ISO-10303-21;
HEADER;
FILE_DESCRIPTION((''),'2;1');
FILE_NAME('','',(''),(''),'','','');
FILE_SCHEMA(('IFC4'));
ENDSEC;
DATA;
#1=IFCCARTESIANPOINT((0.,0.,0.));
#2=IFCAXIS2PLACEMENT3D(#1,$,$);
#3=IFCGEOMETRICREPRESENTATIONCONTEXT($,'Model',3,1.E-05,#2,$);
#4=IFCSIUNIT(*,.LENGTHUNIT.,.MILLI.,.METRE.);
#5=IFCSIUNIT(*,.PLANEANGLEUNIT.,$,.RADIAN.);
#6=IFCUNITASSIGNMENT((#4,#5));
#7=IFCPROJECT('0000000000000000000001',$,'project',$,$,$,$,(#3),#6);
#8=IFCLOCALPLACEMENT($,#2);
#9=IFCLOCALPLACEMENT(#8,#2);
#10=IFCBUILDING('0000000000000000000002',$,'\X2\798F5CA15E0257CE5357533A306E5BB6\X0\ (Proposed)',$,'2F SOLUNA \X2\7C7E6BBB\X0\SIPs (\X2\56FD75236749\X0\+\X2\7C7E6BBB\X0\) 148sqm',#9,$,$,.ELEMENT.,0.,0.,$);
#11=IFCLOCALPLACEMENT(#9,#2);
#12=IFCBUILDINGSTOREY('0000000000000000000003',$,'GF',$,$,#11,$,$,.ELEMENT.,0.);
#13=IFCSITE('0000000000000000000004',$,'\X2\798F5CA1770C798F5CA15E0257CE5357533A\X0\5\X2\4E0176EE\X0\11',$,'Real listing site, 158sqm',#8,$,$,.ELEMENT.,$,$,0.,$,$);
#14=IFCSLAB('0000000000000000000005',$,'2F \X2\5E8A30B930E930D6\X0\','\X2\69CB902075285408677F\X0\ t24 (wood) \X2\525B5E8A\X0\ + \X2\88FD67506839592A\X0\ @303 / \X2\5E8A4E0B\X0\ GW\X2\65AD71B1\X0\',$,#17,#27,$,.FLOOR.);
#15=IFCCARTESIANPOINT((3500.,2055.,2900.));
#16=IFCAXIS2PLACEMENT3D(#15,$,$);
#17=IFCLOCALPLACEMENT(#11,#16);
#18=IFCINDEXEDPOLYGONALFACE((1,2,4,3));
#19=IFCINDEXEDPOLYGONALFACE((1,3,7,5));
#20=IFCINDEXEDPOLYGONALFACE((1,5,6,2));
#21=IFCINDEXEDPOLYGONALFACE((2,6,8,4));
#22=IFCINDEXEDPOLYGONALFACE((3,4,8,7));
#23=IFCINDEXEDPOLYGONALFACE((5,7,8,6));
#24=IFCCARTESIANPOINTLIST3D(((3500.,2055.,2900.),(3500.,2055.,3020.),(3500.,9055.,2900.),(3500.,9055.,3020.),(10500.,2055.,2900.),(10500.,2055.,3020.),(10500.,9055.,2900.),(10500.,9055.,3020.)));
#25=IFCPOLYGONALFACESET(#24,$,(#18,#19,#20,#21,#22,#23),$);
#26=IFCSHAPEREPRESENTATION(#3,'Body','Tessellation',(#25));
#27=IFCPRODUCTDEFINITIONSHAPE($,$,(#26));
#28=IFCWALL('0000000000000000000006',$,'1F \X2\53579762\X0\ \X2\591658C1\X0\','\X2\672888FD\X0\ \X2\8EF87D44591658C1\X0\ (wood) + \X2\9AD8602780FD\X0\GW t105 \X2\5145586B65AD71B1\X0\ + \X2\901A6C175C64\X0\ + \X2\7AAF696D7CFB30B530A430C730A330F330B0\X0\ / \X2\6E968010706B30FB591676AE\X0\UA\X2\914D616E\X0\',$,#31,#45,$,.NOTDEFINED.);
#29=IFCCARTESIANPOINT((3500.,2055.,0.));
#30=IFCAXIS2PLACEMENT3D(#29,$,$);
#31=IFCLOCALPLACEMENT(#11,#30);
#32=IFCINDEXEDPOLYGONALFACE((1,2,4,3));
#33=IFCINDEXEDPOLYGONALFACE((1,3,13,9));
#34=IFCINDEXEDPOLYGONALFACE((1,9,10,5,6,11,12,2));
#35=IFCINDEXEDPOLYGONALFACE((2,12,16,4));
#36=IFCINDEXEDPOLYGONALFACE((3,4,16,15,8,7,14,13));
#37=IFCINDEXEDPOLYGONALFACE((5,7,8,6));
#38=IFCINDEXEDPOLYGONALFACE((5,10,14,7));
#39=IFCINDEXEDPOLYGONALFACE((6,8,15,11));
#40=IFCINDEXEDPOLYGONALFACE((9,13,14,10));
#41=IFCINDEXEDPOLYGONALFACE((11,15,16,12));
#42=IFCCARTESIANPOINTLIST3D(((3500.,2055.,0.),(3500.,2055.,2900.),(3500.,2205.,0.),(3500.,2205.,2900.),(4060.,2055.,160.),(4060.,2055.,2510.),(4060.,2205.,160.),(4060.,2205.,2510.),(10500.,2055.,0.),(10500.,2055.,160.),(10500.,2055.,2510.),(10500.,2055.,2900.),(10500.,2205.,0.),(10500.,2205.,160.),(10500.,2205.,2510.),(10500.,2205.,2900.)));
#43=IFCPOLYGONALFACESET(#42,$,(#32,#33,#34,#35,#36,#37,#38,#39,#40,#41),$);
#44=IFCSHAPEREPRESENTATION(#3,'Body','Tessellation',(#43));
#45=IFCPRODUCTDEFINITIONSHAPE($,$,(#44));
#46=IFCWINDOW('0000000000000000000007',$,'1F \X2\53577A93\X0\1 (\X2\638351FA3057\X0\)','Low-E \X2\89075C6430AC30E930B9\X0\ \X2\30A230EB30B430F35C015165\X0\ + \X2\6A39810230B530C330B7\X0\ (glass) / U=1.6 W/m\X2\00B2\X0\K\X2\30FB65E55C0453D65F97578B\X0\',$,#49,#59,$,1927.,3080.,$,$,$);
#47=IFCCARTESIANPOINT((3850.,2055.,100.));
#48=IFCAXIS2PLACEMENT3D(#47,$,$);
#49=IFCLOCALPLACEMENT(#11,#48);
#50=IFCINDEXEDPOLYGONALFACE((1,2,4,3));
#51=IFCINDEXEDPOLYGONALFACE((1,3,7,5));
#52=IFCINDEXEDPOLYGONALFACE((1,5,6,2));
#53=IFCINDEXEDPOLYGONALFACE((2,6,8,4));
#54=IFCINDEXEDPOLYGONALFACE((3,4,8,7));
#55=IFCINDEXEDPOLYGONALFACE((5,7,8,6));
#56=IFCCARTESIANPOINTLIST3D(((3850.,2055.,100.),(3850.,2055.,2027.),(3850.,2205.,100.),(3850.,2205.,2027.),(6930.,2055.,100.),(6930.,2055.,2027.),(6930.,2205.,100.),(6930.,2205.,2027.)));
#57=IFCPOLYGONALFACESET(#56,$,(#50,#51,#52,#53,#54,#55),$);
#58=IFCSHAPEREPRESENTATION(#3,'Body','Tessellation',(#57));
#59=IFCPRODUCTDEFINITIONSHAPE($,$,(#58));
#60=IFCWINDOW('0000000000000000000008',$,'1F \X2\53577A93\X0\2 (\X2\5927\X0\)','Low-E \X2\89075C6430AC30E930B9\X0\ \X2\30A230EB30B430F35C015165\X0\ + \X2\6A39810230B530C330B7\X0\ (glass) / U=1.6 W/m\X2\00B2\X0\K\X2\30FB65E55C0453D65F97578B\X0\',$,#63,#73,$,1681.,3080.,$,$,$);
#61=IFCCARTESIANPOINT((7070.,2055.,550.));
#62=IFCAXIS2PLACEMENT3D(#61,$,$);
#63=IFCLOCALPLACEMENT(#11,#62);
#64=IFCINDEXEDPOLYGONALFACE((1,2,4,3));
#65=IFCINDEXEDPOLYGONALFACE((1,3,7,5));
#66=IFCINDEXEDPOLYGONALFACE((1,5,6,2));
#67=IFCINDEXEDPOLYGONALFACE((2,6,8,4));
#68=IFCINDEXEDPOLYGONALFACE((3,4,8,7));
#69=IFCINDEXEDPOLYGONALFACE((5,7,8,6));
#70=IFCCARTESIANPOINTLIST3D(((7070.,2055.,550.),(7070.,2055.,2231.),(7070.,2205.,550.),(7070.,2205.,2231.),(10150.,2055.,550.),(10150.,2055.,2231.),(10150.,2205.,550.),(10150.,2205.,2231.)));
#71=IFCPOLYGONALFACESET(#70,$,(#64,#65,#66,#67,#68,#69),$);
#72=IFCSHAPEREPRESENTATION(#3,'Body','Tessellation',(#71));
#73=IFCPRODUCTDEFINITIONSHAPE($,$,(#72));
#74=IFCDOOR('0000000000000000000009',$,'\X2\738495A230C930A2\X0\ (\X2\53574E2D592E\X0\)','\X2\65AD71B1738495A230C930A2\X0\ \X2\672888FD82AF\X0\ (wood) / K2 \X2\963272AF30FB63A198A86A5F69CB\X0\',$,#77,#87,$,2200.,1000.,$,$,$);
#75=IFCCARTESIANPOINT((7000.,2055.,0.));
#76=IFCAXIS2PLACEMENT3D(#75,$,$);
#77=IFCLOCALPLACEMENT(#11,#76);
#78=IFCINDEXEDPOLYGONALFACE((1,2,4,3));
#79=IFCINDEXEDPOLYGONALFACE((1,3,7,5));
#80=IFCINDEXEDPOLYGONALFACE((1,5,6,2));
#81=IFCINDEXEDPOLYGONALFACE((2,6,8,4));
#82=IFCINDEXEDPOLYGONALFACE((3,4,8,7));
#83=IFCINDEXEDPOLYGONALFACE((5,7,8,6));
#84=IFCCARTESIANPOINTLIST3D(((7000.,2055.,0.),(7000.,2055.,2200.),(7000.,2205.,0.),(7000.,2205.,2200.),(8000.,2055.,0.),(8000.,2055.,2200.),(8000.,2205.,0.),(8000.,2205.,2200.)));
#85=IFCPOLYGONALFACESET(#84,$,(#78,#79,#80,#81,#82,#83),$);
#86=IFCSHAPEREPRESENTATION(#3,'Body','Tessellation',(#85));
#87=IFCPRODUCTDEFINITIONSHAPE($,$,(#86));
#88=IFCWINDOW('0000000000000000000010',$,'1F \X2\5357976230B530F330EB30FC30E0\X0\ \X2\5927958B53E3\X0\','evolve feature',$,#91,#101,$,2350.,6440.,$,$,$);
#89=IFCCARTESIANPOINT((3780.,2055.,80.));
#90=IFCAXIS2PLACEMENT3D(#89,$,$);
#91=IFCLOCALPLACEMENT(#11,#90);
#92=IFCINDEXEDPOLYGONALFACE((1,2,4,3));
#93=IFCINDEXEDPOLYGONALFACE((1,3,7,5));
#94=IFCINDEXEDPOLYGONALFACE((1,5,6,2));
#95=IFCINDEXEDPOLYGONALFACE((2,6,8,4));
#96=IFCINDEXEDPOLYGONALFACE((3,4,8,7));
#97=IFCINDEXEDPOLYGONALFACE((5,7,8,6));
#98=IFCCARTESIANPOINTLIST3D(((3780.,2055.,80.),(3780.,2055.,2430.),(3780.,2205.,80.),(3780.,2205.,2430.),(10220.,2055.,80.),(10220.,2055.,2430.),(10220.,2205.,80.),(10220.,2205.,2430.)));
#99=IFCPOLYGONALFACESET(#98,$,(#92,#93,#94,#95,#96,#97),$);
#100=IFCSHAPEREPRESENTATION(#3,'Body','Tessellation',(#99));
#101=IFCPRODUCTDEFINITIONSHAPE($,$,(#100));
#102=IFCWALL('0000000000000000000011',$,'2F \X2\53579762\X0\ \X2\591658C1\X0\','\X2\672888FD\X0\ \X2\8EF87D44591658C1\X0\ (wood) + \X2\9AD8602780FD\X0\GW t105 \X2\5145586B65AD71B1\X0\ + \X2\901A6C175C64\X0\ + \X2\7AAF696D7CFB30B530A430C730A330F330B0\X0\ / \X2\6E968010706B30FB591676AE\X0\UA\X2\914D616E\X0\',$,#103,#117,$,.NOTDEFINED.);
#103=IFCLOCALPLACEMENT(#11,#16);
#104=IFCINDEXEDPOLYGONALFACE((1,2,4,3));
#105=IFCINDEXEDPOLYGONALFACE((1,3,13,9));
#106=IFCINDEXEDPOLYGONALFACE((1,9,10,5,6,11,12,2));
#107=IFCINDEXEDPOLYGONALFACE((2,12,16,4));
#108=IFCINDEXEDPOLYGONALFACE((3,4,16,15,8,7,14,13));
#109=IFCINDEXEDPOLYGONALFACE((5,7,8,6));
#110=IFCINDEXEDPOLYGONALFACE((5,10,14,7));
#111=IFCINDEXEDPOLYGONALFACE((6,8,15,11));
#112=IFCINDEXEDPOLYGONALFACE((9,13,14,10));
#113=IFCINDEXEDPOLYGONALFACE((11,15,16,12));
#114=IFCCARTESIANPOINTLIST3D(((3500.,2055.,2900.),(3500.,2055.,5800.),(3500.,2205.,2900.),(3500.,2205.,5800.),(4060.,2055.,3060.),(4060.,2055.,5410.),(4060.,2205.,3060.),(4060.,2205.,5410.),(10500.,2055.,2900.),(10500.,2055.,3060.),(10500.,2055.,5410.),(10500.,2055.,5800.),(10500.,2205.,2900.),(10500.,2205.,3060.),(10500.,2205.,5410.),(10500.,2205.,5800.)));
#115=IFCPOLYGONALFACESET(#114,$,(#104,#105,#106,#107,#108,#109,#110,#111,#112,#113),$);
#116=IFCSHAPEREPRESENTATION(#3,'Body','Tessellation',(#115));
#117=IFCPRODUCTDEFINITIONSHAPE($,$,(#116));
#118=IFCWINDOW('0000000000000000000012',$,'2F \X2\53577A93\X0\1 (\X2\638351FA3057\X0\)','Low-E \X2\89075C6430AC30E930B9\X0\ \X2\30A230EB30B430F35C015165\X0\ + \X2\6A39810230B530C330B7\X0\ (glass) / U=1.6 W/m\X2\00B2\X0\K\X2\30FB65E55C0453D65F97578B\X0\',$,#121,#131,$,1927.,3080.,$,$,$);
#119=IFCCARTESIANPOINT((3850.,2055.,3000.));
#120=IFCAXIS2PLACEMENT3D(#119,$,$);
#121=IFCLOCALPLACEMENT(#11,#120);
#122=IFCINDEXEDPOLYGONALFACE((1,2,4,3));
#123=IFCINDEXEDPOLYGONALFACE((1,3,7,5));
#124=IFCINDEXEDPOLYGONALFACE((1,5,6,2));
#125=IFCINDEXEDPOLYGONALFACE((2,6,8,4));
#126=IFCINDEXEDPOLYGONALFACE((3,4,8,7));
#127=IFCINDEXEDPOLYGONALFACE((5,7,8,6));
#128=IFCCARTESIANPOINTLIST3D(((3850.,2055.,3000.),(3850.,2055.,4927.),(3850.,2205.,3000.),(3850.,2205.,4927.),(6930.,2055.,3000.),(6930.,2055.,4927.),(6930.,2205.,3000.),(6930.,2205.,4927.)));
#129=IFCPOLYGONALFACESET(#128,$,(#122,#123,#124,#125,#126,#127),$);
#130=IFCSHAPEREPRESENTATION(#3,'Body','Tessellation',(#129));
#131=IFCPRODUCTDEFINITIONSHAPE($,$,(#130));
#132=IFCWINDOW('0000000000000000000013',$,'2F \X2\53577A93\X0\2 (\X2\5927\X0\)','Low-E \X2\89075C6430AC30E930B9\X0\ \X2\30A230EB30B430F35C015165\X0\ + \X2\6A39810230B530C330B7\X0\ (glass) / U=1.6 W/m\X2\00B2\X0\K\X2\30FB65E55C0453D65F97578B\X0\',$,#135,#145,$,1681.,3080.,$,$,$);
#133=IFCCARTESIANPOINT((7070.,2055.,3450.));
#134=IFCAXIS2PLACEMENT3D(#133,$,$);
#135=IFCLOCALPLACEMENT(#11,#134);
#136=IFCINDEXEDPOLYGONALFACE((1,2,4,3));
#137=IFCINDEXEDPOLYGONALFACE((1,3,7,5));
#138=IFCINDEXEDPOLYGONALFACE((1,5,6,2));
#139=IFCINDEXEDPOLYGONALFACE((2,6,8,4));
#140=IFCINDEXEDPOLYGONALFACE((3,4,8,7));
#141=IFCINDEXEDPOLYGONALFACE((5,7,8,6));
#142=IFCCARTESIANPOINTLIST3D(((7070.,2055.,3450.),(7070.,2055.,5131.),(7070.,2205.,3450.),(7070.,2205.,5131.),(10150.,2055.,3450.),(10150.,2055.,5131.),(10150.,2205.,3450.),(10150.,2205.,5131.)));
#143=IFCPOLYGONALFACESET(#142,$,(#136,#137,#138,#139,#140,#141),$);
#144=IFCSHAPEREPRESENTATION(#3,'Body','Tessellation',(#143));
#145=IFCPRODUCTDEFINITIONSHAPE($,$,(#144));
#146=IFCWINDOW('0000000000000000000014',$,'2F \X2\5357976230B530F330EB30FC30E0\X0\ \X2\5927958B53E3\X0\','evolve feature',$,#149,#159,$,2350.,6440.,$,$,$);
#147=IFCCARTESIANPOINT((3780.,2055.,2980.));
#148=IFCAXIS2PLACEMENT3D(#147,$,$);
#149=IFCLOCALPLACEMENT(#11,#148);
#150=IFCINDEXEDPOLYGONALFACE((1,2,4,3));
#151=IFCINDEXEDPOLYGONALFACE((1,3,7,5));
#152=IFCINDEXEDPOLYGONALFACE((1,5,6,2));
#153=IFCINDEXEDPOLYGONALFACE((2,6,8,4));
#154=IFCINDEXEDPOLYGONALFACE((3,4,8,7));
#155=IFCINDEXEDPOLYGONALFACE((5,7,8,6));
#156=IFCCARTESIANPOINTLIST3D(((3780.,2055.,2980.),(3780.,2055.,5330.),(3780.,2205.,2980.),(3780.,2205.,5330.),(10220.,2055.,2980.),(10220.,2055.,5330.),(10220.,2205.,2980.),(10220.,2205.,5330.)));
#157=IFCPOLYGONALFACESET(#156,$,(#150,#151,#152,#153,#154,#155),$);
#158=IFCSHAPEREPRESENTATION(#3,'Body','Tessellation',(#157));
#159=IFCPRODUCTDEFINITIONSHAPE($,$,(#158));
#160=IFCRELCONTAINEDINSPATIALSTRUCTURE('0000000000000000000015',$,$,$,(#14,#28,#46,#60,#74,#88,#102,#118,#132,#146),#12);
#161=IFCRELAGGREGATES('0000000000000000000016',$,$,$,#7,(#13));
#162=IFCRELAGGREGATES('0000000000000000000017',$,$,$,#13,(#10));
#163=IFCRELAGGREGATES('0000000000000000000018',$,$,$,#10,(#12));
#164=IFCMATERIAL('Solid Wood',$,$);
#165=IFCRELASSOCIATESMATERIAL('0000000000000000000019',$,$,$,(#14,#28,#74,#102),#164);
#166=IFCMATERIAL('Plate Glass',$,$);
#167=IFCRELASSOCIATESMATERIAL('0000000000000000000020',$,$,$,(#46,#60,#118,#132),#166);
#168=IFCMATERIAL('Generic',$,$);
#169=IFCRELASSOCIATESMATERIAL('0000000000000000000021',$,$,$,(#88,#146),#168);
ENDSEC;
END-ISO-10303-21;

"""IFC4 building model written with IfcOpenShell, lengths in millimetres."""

from ifc_helpers import new_model, si_unit, frame, frame_2d, origin, place, context, project, spatial, rectangle, extrude, material, element, fill, save


model = new_model("IFC4")

# Units and contexts
model_context = context("Model", 3, precision=1e-05, world=origin())
ifc_project = project(units=[si_unit("LENGTHUNIT", "METRE", prefix="MILLI"), si_unit("PLANEANGLEUNIT", "RADIAN")], contexts=[model_context])

# Site, building, storey
site_placement = place(None, origin())
site = spatial("IfcSite", under=ifc_project, at=site_placement, Name="福岡県福岡市城南区5丁目11", ObjectType="Real listing site, 158sqm", CompositionType="ELEMENT", RefElevation=0.0)
building_placement = place(site_placement, origin())
building = spatial("IfcBuilding", under=site, at=building_placement, Name="福岡市城南区の家 (Proposed)", ObjectType="2F SOLUNA 籾殻SIPs (国産杉+籾殻) 148sqm", CompositionType="ELEMENT", ElevationOfRefHeight=0.0, ElevationOfTerrain=0.0)
storey_placement = place(building_placement, origin())
storey = spatial("IfcBuildingStorey", under=building, at=storey_placement, Name="GF", CompositionType="ELEMENT", Elevation=0.0)

# Slab
ifc_material_1 = material(Name="Solid Wood")
slab_1_placement = place(storey_placement, frame((3500.0, 2055.0, 2900.0)))
element("IfcSlab", 1, at=slab_1_placement, inside=storey, material=ifc_material_1, Name="2F 床スラブ", Description="構造用合板 t24 (wood) 剛床 + 製材根太 @303 / 床下 GW断熱", PredefinedType="FLOOR", context=model_context, shape_type="SweptSolid", body=[
    extrude(rectangle(XDim=7000.0, YDim=7000.0, at=frame_2d((3500.0, 3500.0))), frame((3500.0, 2055.0, 2900.0)), (0.0, 0.0, 1.0), 120.0),
])
ifc_material_2 = material(Name="Generic")

# Wall, openings, windows, door
wall_1_placement = place(storey_placement, frame((3500.0, 2055.0, 0.0)))
wall_1 = element("IfcWall", 2, at=wall_1_placement, inside=storey, material=ifc_material_1, Name="1F 南面 外壁", Description="木製 軸組外壁 (wood) + 高性能GW t105 充填断熱 + 通気層 + 窯業系サイディング / 準耐火・外皮UA配慮", PredefinedType="NOTDEFINED", context=model_context, shape_type="SweptSolid", body=[
    extrude(rectangle(XDim=7000.0, YDim=150.0, at=frame_2d((3500.0, 75.0))), frame((3500.0, 2055.0, 0.0)), (0.0, 0.0, 1.0), 2900.0),
])
opening_1_placement = place(storey_placement, frame((3850.0, 2055.0, 100.0)))
opening_1 = element("IfcOpeningElement", 3, at=opening_1_placement, cuts=wall_1, PredefinedType="NOTDEFINED", context=model_context, shape_type="SweptSolid", body=[
    extrude(rectangle(XDim=3080.0, YDim=150.0, at=frame_2d((1540.0, 75.0))), frame((3850.0, 2055.0, 100.0)), (0.0, 0.0, 1.0), 1927.0),
])
opening_2_placement = place(storey_placement, frame((7070.0, 2055.0, 550.0)))
opening_2 = element("IfcOpeningElement", 4, at=opening_2_placement, cuts=wall_1, PredefinedType="NOTDEFINED", context=model_context, shape_type="SweptSolid", body=[
    extrude(rectangle(XDim=3080.0, YDim=150.0, at=frame_2d((1540.0, 75.0))), frame((7070.0, 2055.0, 550.0)), (0.0, 0.0, 1.0), 1681.0),
])
opening_3_placement = place(storey_placement, frame((7000.0, 2055.0, 0.0)))
opening_3 = element("IfcOpeningElement", 5, at=opening_3_placement, cuts=wall_1, PredefinedType="NOTDEFINED", context=model_context, shape_type="SweptSolid", body=[
    extrude(rectangle(XDim=1000.0, YDim=150.0, at=frame_2d((500.0, 75.0))), frame((7000.0, 2055.0, 0.0)), (0.0, 0.0, 1.0), 2200.0),
])
opening_4_placement = place(storey_placement, frame((3780.0, 2055.0, 80.0)))
opening_4 = element("IfcOpeningElement", 6, at=opening_4_placement, cuts=wall_1, PredefinedType="NOTDEFINED", context=model_context, shape_type="SweptSolid", body=[
    extrude(rectangle(XDim=6440.0, YDim=150.0, at=frame_2d((3220.0, 75.0))), frame((3780.0, 2055.0, 80.0)), (0.0, 0.0, 1.0), 2350.0),
])
ifc_material_3 = material(Name="Plate Glass")
window_1_placement = place(storey_placement, frame((3850.0, 2055.0, 100.0)))
window_1 = element("IfcWindow", 7, at=window_1_placement, inside=storey, material=ifc_material_3, Name="1F 南窓1 (掃出し)", Description="Low-E 複層ガラス アルゴン封入 + 樹脂サッシ (glass) / U=1.6 W/m²K・日射取得型", OverallHeight=1927.0, OverallWidth=3080.0, context=model_context, shape_type="SweptSolid", body=[
    extrude(rectangle(XDim=3080.0, YDim=150.0, at=frame_2d((1540.0, 75.0))), frame((3850.0, 2055.0, 100.0)), (0.0, 0.0, 1.0), 1927.0),
])
fill(opening_1, window_1)
window_2_placement = place(storey_placement, frame((7070.0, 2055.0, 550.0)))
window_2 = element("IfcWindow", 8, at=window_2_placement, inside=storey, material=ifc_material_3, Name="1F 南窓2 (大)", Description="Low-E 複層ガラス アルゴン封入 + 樹脂サッシ (glass) / U=1.6 W/m²K・日射取得型", OverallHeight=1681.0, OverallWidth=3080.0, context=model_context, shape_type="SweptSolid", body=[
    extrude(rectangle(XDim=3080.0, YDim=150.0, at=frame_2d((1540.0, 75.0))), frame((7070.0, 2055.0, 550.0)), (0.0, 0.0, 1.0), 1681.0),
])
fill(opening_2, window_2)
door_placement = place(storey_placement, frame((7000.0, 2055.0, 0.0)))
door = element("IfcDoor", 9, at=door_placement, inside=storey, material=ifc_material_1, Name="玄関ドア (南中央)", Description="断熱玄関ドア 木製芯 (wood) / K2 防犯・採風機構", OverallHeight=2200.0, OverallWidth=1000.0, context=model_context, shape_type="SweptSolid", body=[
    extrude(rectangle(XDim=1000.0, YDim=150.0, at=frame_2d((500.0, 75.0))), frame((7000.0, 2055.0, 0.0)), (0.0, 0.0, 1.0), 2200.0),
])
fill(opening_3, door)
window_3_placement = place(storey_placement, frame((3780.0, 2055.0, 80.0)))
window_3 = element("IfcWindow", 10, at=window_3_placement, inside=storey, material=ifc_material_2, Name="1F 南面サンルーム 大開口", Description="evolve feature", OverallHeight=2350.0, OverallWidth=6440.0, context=model_context, shape_type="SweptSolid", body=[
    extrude(rectangle(XDim=6440.0, YDim=150.0, at=frame_2d((3220.0, 75.0))), frame((3780.0, 2055.0, 80.0)), (0.0, 0.0, 1.0), 2350.0),
])
fill(opening_4, window_3)

# Wall, openings, windows
wall_2_placement = place(storey_placement, frame((3500.0, 2055.0, 2900.0)))
wall_2 = element("IfcWall", 11, at=wall_2_placement, inside=storey, material=ifc_material_1, Name="2F 南面 外壁", Description="木製 軸組外壁 (wood) + 高性能GW t105 充填断熱 + 通気層 + 窯業系サイディング / 準耐火・外皮UA配慮", PredefinedType="NOTDEFINED", context=model_context, shape_type="SweptSolid", body=[
    extrude(rectangle(XDim=7000.0, YDim=150.0, at=frame_2d((3500.0, 75.0))), frame((3500.0, 2055.0, 2900.0)), (0.0, 0.0, 1.0), 2900.0),
])
opening_5_placement = place(storey_placement, frame((3850.0, 2055.0, 3000.0)))
opening_5 = element("IfcOpeningElement", 12, at=opening_5_placement, cuts=wall_2, PredefinedType="NOTDEFINED", context=model_context, shape_type="SweptSolid", body=[
    extrude(rectangle(XDim=3080.0, YDim=150.0, at=frame_2d((1540.0, 75.0))), frame((3850.0, 2055.0, 3000.0)), (0.0, 0.0, 1.0), 1927.0),
])
opening_6_placement = place(storey_placement, frame((7070.0, 2055.0, 3450.0)))
opening_6 = element("IfcOpeningElement", 13, at=opening_6_placement, cuts=wall_2, PredefinedType="NOTDEFINED", context=model_context, shape_type="SweptSolid", body=[
    extrude(rectangle(XDim=3080.0, YDim=150.0, at=frame_2d((1540.0, 75.0))), frame((7070.0, 2055.0, 3450.0)), (0.0, 0.0, 1.0), 1681.0),
])
opening_7_placement = place(storey_placement, frame((3780.0, 2055.0, 2980.0)))
opening_7 = element("IfcOpeningElement", 14, at=opening_7_placement, cuts=wall_2, PredefinedType="NOTDEFINED", context=model_context, shape_type="SweptSolid", body=[
    extrude(rectangle(XDim=6440.0, YDim=150.0, at=frame_2d((3220.0, 75.0))), frame((3780.0, 2055.0, 2980.0)), (0.0, 0.0, 1.0), 2350.0),
])
window_4_placement = place(storey_placement, frame((3850.0, 2055.0, 3000.0)))
window_4 = element("IfcWindow", 15, at=window_4_placement, inside=storey, material=ifc_material_3, Name="2F 南窓1 (掃出し)", Description="Low-E 複層ガラス アルゴン封入 + 樹脂サッシ (glass) / U=1.6 W/m²K・日射取得型", OverallHeight=1927.0, OverallWidth=3080.0, context=model_context, shape_type="SweptSolid", body=[
    extrude(rectangle(XDim=3080.0, YDim=150.0, at=frame_2d((1540.0, 75.0))), frame((3850.0, 2055.0, 3000.0)), (0.0, 0.0, 1.0), 1927.0),
])
fill(opening_5, window_4)
window_5_placement = place(storey_placement, frame((7070.0, 2055.0, 3450.0)))
window_5 = element("IfcWindow", 16, at=window_5_placement, inside=storey, material=ifc_material_3, Name="2F 南窓2 (大)", Description="Low-E 複層ガラス アルゴン封入 + 樹脂サッシ (glass) / U=1.6 W/m²K・日射取得型", OverallHeight=1681.0, OverallWidth=3080.0, context=model_context, shape_type="SweptSolid", body=[
    extrude(rectangle(XDim=3080.0, YDim=150.0, at=frame_2d((1540.0, 75.0))), frame((7070.0, 2055.0, 3450.0)), (0.0, 0.0, 1.0), 1681.0),
])
fill(opening_6, window_5)
window_6_placement = place(storey_placement, frame((3780.0, 2055.0, 2980.0)))
window_6 = element("IfcWindow", 17, at=window_6_placement, inside=storey, material=ifc_material_2, Name="2F 南面サンルーム 大開口", Description="evolve feature", OverallHeight=2350.0, OverallWidth=6440.0, context=model_context, shape_type="SweptSolid", body=[
    extrude(rectangle(XDim=6440.0, YDim=150.0, at=frame_2d((3220.0, 75.0))), frame((3780.0, 2055.0, 2980.0)), (0.0, 0.0, 1.0), 2350.0),
])
fill(opening_7, window_6)

save(model, "model.ifc")
